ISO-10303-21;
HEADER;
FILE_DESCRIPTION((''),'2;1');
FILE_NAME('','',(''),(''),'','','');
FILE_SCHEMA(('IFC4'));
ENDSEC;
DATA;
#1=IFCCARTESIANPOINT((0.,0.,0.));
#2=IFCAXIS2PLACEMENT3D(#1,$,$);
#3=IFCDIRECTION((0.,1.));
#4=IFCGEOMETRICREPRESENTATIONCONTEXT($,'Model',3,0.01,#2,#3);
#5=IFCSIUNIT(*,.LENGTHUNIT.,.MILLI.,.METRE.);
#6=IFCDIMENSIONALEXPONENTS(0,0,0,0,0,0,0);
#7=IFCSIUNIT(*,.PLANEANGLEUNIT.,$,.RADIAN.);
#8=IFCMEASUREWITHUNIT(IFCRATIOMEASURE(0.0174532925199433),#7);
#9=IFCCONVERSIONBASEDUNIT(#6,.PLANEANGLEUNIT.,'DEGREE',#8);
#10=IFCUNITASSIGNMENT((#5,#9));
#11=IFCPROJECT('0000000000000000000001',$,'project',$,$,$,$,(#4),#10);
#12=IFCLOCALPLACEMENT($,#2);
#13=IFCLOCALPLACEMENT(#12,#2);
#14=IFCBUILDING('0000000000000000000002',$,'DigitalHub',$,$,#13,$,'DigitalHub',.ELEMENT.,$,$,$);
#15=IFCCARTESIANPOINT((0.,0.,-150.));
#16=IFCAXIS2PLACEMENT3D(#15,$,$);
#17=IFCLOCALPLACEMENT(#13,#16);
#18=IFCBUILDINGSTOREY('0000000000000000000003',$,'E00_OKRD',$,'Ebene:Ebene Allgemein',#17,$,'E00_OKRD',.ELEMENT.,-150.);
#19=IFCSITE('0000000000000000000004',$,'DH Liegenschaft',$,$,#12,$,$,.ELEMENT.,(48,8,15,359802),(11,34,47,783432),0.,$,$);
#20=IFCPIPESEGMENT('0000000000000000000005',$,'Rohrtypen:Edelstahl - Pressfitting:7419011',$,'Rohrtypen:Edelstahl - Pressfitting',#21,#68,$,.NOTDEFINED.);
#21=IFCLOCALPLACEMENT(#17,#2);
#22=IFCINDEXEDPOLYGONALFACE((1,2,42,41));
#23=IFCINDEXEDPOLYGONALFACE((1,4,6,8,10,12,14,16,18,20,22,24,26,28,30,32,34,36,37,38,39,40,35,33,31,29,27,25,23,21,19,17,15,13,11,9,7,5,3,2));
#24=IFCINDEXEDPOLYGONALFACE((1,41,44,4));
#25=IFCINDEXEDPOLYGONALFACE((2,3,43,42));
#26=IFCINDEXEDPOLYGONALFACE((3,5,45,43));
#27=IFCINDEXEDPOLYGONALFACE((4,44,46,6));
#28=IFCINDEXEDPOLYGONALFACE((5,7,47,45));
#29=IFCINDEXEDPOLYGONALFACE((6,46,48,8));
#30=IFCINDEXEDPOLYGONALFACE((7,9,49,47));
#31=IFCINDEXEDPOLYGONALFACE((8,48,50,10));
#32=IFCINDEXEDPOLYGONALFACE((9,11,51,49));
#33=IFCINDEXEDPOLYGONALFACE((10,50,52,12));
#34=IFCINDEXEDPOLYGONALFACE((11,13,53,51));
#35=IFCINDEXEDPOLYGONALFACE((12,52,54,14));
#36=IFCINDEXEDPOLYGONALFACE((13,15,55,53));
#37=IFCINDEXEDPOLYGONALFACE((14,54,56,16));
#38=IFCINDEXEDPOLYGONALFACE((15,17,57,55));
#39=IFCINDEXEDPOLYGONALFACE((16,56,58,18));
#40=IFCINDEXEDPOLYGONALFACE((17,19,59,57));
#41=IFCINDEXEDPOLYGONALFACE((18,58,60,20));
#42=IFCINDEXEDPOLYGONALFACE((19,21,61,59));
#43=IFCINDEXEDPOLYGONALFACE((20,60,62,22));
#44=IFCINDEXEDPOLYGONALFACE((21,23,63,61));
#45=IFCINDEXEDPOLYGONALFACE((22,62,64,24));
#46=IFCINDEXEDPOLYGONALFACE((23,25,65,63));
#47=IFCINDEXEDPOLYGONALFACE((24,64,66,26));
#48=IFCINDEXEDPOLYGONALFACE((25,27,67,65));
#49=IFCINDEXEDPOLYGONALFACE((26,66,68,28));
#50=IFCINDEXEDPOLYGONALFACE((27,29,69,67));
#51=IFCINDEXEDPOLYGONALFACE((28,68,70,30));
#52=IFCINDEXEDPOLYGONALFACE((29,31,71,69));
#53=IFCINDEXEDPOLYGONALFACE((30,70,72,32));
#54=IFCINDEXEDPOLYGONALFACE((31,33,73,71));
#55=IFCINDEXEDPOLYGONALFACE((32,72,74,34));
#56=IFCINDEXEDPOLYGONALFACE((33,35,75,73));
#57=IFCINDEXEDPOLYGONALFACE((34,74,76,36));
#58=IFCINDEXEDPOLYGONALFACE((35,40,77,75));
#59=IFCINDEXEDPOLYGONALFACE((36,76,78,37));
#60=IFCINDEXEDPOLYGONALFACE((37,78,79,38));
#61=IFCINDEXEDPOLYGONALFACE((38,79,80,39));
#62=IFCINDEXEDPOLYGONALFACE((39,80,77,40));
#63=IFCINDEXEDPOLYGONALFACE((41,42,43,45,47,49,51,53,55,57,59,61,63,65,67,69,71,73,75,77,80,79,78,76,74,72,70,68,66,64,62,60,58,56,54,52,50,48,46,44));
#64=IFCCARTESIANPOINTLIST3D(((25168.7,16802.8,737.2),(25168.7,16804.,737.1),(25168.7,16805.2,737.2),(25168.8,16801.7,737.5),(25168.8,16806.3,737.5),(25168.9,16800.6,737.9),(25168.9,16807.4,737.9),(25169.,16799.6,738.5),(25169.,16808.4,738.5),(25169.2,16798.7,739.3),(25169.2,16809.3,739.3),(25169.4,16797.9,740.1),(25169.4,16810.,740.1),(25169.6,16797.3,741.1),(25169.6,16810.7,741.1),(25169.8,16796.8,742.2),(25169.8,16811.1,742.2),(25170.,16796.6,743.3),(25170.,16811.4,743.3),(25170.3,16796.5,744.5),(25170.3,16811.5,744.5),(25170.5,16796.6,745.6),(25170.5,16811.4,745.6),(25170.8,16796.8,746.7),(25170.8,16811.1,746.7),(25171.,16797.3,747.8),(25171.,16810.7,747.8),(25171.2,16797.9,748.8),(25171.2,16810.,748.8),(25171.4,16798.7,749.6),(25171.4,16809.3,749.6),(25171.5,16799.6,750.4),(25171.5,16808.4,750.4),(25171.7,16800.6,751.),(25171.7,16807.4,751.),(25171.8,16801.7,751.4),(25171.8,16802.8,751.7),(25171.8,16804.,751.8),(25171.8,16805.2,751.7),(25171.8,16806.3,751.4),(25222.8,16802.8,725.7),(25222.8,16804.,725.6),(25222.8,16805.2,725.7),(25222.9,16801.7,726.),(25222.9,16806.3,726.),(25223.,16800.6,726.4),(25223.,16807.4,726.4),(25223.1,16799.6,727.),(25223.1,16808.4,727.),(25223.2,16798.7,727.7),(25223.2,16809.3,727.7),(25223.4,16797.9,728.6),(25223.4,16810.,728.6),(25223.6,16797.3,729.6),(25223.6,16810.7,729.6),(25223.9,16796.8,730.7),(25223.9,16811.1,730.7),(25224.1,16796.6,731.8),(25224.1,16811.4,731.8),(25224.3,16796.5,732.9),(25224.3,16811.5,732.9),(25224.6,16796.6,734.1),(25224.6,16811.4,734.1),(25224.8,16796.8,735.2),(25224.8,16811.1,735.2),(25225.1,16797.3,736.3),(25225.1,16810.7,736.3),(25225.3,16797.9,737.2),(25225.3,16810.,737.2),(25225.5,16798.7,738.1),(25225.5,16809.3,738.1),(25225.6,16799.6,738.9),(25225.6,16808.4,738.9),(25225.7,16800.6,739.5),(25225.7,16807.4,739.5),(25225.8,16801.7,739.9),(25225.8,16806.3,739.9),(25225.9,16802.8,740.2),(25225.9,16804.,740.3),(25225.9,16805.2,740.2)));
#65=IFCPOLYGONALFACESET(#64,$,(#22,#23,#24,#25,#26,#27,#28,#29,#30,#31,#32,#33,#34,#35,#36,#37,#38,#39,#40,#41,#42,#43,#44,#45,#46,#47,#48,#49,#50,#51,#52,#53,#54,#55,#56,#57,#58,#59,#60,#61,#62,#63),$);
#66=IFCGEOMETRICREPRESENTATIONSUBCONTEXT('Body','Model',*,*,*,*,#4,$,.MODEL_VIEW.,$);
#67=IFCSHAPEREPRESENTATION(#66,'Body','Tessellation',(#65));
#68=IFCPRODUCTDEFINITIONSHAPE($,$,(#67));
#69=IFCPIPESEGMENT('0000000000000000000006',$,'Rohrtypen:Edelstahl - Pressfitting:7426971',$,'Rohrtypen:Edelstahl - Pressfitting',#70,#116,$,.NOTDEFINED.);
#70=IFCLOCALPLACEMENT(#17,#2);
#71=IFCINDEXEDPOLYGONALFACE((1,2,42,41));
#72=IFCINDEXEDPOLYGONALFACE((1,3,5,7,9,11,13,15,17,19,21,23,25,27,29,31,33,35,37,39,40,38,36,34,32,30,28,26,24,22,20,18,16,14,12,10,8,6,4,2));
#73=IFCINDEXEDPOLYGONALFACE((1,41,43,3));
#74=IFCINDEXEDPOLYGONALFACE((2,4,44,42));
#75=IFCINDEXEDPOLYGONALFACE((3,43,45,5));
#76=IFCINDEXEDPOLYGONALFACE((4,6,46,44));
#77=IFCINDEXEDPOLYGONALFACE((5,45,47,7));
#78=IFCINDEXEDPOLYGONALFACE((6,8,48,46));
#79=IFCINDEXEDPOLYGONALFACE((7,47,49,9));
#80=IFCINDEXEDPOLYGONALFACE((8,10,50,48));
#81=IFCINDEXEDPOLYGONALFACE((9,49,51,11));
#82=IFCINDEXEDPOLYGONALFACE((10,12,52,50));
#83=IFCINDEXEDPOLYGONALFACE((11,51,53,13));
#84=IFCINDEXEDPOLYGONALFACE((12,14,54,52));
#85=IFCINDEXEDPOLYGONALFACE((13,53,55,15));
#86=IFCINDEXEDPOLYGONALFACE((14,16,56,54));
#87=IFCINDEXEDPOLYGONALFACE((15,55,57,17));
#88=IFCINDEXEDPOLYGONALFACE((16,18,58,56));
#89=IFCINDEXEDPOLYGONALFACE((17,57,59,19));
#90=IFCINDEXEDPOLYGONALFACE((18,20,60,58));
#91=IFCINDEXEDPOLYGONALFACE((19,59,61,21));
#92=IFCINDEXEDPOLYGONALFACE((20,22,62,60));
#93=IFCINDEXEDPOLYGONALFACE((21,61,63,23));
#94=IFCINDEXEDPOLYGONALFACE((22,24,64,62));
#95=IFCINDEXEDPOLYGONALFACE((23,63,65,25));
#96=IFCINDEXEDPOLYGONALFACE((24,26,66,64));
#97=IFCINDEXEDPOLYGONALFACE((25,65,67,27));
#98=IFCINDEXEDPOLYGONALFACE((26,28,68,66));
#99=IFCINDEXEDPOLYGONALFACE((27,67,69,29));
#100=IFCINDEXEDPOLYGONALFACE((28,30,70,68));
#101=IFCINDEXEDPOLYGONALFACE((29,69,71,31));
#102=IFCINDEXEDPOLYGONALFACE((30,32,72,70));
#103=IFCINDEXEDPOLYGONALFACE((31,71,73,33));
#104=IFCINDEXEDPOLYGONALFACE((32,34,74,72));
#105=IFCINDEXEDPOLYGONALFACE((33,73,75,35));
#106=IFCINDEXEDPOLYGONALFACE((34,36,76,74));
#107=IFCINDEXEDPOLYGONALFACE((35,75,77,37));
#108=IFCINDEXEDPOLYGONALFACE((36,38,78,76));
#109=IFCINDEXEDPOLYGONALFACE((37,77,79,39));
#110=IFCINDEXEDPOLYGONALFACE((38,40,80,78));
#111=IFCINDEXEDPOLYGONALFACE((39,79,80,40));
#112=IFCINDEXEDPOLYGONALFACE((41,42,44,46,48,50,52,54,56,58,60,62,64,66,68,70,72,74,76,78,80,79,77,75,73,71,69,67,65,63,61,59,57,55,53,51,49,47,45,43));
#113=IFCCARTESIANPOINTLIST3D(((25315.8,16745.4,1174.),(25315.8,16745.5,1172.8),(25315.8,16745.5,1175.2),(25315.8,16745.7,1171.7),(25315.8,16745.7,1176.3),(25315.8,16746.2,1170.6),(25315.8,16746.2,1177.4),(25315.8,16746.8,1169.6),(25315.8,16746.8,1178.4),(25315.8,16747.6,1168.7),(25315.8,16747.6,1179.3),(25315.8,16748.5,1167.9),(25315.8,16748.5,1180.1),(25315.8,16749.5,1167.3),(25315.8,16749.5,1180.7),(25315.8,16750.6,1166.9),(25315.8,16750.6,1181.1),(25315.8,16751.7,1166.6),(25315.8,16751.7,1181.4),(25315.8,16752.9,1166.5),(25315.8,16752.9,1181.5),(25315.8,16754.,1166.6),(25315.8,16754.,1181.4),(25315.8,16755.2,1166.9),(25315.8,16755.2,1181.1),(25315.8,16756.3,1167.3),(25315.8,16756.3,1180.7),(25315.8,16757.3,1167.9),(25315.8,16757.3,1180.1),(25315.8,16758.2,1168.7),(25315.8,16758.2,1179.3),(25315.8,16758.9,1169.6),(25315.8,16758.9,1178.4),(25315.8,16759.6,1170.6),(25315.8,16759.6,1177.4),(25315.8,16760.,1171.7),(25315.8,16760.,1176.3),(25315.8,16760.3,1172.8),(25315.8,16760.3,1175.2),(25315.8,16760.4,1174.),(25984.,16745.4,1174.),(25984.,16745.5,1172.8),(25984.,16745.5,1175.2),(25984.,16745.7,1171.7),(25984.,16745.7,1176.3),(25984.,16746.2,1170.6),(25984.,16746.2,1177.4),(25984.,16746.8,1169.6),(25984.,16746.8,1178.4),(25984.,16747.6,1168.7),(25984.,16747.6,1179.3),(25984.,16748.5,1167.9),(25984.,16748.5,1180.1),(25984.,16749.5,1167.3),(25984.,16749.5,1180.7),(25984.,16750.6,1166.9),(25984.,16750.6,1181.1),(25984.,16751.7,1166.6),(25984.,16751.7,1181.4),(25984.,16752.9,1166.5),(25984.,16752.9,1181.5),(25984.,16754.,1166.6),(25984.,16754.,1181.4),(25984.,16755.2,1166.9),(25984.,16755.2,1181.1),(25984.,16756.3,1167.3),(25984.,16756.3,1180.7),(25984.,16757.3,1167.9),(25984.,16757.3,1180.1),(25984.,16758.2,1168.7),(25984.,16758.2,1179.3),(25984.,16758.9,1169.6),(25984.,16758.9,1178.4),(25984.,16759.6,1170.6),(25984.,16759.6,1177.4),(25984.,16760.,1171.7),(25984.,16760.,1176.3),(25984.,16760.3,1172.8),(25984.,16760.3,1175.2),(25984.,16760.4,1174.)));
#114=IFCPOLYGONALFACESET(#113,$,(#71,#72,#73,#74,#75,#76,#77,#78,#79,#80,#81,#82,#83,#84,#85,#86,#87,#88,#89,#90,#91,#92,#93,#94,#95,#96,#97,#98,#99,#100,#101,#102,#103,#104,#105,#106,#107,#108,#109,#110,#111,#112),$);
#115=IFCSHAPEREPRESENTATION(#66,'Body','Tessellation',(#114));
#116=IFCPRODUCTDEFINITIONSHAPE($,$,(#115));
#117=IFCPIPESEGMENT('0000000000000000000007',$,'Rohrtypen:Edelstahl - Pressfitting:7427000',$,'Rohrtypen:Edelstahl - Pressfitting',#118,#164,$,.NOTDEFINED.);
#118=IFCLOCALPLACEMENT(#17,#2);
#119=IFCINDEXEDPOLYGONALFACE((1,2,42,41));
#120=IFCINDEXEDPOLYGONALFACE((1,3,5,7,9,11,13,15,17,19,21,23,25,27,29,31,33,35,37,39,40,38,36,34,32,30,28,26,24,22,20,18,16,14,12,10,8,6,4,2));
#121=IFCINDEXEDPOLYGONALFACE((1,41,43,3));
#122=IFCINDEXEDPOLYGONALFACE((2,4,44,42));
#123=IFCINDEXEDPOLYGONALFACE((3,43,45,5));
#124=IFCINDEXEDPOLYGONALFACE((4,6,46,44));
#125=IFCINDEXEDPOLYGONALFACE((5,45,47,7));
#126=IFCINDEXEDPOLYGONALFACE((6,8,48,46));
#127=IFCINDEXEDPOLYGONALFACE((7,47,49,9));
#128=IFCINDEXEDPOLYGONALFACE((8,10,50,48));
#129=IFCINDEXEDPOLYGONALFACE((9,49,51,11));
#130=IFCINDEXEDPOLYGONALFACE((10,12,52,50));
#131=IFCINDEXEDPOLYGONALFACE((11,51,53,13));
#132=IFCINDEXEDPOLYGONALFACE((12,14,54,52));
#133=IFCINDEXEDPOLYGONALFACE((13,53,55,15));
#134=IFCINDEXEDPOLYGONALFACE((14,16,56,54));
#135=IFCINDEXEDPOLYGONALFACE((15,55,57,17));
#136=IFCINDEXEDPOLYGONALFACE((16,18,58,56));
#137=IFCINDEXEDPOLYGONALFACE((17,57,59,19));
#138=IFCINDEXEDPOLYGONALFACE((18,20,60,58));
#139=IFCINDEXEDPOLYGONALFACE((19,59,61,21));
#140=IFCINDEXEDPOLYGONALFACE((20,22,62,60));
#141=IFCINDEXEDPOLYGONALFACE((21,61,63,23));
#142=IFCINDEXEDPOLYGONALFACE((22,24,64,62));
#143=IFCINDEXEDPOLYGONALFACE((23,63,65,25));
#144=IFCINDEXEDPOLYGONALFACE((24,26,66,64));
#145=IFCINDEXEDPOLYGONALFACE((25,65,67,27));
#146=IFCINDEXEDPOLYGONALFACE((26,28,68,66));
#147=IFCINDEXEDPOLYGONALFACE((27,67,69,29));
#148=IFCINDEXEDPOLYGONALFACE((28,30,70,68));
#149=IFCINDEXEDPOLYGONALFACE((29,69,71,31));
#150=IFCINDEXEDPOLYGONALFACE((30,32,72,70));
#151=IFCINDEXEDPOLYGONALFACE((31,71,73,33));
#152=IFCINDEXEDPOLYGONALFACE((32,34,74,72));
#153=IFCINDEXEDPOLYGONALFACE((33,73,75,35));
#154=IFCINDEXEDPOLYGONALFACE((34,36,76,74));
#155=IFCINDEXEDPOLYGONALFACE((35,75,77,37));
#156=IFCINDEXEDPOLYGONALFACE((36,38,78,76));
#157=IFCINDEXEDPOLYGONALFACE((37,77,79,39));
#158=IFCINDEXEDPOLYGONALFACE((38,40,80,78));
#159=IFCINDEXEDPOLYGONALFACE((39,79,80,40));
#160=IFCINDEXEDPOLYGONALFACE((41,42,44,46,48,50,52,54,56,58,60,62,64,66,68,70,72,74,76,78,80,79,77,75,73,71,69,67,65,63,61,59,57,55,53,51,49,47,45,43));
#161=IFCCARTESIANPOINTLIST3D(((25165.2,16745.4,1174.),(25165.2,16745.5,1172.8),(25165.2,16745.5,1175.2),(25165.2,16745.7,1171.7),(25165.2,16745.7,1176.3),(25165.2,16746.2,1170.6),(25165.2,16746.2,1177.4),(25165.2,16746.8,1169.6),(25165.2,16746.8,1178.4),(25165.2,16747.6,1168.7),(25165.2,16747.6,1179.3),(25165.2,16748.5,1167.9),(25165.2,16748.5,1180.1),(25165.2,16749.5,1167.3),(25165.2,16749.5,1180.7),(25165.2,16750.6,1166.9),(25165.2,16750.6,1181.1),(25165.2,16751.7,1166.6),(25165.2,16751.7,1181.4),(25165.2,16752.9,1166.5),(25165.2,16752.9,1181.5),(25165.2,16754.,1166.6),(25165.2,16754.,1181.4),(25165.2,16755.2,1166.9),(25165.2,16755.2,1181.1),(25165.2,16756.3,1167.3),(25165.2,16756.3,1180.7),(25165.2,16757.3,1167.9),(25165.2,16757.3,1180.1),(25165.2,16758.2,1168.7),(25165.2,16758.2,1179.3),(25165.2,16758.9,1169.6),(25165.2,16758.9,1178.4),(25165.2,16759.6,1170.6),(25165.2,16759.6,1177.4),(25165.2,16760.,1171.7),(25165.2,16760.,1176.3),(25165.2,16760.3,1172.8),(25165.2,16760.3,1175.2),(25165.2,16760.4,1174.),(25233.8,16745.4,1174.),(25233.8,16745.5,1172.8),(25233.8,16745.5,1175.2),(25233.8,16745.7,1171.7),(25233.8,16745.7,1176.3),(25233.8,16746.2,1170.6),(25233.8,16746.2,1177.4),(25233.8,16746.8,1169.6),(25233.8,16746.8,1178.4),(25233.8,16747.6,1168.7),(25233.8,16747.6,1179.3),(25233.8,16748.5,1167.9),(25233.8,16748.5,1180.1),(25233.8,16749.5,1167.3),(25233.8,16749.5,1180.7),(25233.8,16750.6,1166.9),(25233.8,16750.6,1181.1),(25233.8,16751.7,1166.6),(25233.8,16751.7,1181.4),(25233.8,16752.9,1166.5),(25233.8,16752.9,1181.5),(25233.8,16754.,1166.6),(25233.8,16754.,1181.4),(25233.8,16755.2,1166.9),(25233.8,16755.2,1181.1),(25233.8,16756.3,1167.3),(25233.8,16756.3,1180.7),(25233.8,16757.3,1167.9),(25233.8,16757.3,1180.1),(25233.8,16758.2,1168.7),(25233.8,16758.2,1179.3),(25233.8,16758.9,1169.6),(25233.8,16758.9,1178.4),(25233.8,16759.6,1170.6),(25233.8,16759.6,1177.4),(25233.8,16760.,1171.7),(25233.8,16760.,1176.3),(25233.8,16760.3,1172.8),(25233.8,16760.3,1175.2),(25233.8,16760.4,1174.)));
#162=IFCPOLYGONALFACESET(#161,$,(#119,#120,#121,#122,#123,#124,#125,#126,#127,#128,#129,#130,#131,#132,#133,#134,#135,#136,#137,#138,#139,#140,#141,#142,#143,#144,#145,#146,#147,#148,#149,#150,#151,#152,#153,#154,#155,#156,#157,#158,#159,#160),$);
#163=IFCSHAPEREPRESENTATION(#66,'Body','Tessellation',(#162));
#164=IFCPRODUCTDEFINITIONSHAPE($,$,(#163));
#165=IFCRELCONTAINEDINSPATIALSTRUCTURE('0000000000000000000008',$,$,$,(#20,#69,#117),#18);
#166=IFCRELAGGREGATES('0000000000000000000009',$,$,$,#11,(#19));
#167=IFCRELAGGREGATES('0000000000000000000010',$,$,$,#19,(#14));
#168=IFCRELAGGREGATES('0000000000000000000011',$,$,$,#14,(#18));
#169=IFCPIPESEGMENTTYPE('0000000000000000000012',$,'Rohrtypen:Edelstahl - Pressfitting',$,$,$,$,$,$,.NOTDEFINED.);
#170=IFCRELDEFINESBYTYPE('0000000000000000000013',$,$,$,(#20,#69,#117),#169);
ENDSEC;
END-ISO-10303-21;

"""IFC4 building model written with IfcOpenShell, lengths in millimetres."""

from ifc_helpers import new_model, entity, si_unit, converted_unit, direction, frame, origin, place, context, subcontext, project, spatial, indexed_curve, outline, extrude, type_object, element, save


model = new_model("IFC4")

# Units and contexts
model_context = context("Model", 3, precision=0.01, world=origin(), true_north=direction((0.0, 1.0)))
body_context = subcontext(model_context, "Body", "Model", "MODEL_VIEW")
ifc_project = project(units=[si_unit("LENGTHUNIT", "METRE", prefix="MILLI"), converted_unit("PLANEANGLEUNIT", "DEGREE", entity("IfcRatioMeasure", 0.0174532925199433), si_unit("PLANEANGLEUNIT", "RADIAN"), dimensions=[0, 0, 0, 0, 0, 0, 0])], contexts=[model_context])

# Site, building, storey
site_placement = place(None, origin())
site = spatial("IfcSite", under=ifc_project, at=site_placement, Name="DH Liegenschaft", CompositionType="ELEMENT", RefLatitude=(48, 8, 15, 359802), RefLongitude=(11, 34, 47, 783432), RefElevation=0.0)
building_placement = place(site_placement, origin())
building = spatial("IfcBuilding", under=site, at=building_placement, Name="DigitalHub", LongName="DigitalHub", CompositionType="ELEMENT")
storey_placement = place(building_placement, frame((0.0, 0.0, -150.0)))
storey = spatial("IfcBuildingStorey", under=building, at=storey_placement, Name="E00_OKRD", ObjectType="Ebene:Ebene Allgemein", LongName="E00_OKRD", CompositionType="ELEMENT", Elevation=-150.0)

# Pipe segments
pipe_segment_type_1 = type_object("IfcPipeSegmentType", Name="Rohrtypen:Edelstahl - Pressfitting", PredefinedType="NOTDEFINED")
pipe_segment_1_placement = place(storey_placement, frame((25167.1, 16794.9, 724.0)))
element("IfcPipeSegment", 1, at=pipe_segment_1_placement, inside=storey, type_object=pipe_segment_type_1, Name="Rohrtypen:Edelstahl - Pressfitting:7419011", ObjectType="Rohrtypen:Edelstahl - Pressfitting", PredefinedType="NOTDEFINED", context=body_context, shape_type="SweptSolid", body=[
    extrude(outline(indexed_curve([(7.5, 0.0), (7.4, 1.2), (7.1, 2.3), (6.7, 3.4), (6.1, 4.4), (5.3, 5.3), (4.4, 6.1), (3.4, 6.7), (2.3, 7.1), (1.2, 7.4), (0.0, 7.5), (-1.2, 7.4), (-2.3, 7.1), (-3.4, 6.7), (-4.4, 6.1), (-5.3, 5.3), (-6.1, 4.4), (-6.7, 3.4), (-7.1, 2.3), (-7.4, 1.2), (-7.5, 0.0), (-7.4, -1.2), (-7.1, -2.3), (-6.7, -3.4), (-6.1, -4.4), (-5.3, -5.3), (-4.4, -6.1), (-3.4, -6.7), (-2.3, -7.1), (-1.2, -7.4), (0.0, -7.5), (1.2, -7.4), (2.3, -7.1), (3.4, -6.7), (4.4, -6.1), (5.3, -5.3), (6.1, -4.4), (6.7, -3.4), (7.1, -2.3), (7.4, -1.2), (7.5, 0.0)], self_intersect=False)), frame((57.2, 9.1, 8.9), z_axis=(-0.978044, 0.0, 0.208399), x_axis=(0.0, 1.0, 0.0)), (0.0, 0.0, 1.0), 55.3),
])
pipe_segment_2_placement = place(storey_placement, frame((25315.8, 16743.8, 1164.9)))
element("IfcPipeSegment", 2, at=pipe_segment_2_placement, inside=storey, type_object=pipe_segment_type_1, Name="Rohrtypen:Edelstahl - Pressfitting:7426971", ObjectType="Rohrtypen:Edelstahl - Pressfitting", PredefinedType="NOTDEFINED", context=body_context, shape_type="SweptSolid", body=[
    extrude(outline(indexed_curve([(7.5, 0.0), (7.4, 1.2), (7.1, 2.3), (6.7, 3.4), (6.1, 4.4), (5.3, 5.3), (4.4, 6.1), (3.4, 6.7), (2.3, 7.1), (1.2, 7.4), (0.0, 7.5), (-1.2, 7.4), (-2.3, 7.1), (-3.4, 6.7), (-4.4, 6.1), (-5.3, 5.3), (-6.1, 4.4), (-6.7, 3.4), (-7.1, 2.3), (-7.4, 1.2), (-7.5, 0.0), (-7.4, -1.2), (-7.1, -2.3), (-6.7, -3.4), (-6.1, -4.4), (-5.3, -5.3), (-4.4, -6.1), (-3.4, -6.7), (-2.3, -7.1), (-1.2, -7.4), (0.0, -7.5), (1.2, -7.4), (2.3, -7.1), (3.4, -6.7), (4.4, -6.1), (5.3, -5.3), (6.1, -4.4), (6.7, -3.4), (7.1, -2.3), (7.4, -1.2), (7.5, 0.0)], self_intersect=False)), frame((0.0, 9.1, 9.1), z_axis=(1.0, 0.0, 0.00001), x_axis=(0.0, 1.0, 0.0)), (0.0, 0.0, 1.0), 668.1),
])
pipe_segment_3_placement = place(storey_placement, frame((25165.2, 16743.8, 1164.9)))
element("IfcPipeSegment", 3, at=pipe_segment_3_placement, inside=storey, type_object=pipe_segment_type_1, Name="Rohrtypen:Edelstahl - Pressfitting:7427000", ObjectType="Rohrtypen:Edelstahl - Pressfitting", PredefinedType="NOTDEFINED", context=body_context, shape_type="SweptSolid", body=[
    extrude(outline(indexed_curve([(7.5, 0.0), (7.4, 1.2), (7.1, 2.3), (6.7, 3.4), (6.1, 4.4), (5.3, 5.3), (4.4, 6.1), (3.4, 6.7), (2.3, 7.1), (1.2, 7.4), (0.0, 7.5), (-1.2, 7.4), (-2.3, 7.1), (-3.4, 6.7), (-4.4, 6.1), (-5.3, 5.3), (-6.1, 4.4), (-6.7, 3.4), (-7.1, 2.3), (-7.4, 1.2), (-7.5, 0.0), (-7.4, -1.2), (-7.1, -2.3), (-6.7, -3.4), (-6.1, -4.4), (-5.3, -5.3), (-4.4, -6.1), (-3.4, -6.7), (-2.3, -7.1), (-1.2, -7.4), (0.0, -7.5), (1.2, -7.4), (2.3, -7.1), (3.4, -6.7), (4.4, -6.1), (5.3, -5.3), (6.1, -4.4), (6.7, -3.4), (7.1, -2.3), (7.4, -1.2), (7.5, 0.0)], self_intersect=False)), frame((0.0, 9.1, 9.1), z_axis=(1.0, 0.0, 0.00001), x_axis=(0.0, 1.0, 0.0)), (0.0, 0.0, 1.0), 68.6),
])

save(model, "model.ifc")
